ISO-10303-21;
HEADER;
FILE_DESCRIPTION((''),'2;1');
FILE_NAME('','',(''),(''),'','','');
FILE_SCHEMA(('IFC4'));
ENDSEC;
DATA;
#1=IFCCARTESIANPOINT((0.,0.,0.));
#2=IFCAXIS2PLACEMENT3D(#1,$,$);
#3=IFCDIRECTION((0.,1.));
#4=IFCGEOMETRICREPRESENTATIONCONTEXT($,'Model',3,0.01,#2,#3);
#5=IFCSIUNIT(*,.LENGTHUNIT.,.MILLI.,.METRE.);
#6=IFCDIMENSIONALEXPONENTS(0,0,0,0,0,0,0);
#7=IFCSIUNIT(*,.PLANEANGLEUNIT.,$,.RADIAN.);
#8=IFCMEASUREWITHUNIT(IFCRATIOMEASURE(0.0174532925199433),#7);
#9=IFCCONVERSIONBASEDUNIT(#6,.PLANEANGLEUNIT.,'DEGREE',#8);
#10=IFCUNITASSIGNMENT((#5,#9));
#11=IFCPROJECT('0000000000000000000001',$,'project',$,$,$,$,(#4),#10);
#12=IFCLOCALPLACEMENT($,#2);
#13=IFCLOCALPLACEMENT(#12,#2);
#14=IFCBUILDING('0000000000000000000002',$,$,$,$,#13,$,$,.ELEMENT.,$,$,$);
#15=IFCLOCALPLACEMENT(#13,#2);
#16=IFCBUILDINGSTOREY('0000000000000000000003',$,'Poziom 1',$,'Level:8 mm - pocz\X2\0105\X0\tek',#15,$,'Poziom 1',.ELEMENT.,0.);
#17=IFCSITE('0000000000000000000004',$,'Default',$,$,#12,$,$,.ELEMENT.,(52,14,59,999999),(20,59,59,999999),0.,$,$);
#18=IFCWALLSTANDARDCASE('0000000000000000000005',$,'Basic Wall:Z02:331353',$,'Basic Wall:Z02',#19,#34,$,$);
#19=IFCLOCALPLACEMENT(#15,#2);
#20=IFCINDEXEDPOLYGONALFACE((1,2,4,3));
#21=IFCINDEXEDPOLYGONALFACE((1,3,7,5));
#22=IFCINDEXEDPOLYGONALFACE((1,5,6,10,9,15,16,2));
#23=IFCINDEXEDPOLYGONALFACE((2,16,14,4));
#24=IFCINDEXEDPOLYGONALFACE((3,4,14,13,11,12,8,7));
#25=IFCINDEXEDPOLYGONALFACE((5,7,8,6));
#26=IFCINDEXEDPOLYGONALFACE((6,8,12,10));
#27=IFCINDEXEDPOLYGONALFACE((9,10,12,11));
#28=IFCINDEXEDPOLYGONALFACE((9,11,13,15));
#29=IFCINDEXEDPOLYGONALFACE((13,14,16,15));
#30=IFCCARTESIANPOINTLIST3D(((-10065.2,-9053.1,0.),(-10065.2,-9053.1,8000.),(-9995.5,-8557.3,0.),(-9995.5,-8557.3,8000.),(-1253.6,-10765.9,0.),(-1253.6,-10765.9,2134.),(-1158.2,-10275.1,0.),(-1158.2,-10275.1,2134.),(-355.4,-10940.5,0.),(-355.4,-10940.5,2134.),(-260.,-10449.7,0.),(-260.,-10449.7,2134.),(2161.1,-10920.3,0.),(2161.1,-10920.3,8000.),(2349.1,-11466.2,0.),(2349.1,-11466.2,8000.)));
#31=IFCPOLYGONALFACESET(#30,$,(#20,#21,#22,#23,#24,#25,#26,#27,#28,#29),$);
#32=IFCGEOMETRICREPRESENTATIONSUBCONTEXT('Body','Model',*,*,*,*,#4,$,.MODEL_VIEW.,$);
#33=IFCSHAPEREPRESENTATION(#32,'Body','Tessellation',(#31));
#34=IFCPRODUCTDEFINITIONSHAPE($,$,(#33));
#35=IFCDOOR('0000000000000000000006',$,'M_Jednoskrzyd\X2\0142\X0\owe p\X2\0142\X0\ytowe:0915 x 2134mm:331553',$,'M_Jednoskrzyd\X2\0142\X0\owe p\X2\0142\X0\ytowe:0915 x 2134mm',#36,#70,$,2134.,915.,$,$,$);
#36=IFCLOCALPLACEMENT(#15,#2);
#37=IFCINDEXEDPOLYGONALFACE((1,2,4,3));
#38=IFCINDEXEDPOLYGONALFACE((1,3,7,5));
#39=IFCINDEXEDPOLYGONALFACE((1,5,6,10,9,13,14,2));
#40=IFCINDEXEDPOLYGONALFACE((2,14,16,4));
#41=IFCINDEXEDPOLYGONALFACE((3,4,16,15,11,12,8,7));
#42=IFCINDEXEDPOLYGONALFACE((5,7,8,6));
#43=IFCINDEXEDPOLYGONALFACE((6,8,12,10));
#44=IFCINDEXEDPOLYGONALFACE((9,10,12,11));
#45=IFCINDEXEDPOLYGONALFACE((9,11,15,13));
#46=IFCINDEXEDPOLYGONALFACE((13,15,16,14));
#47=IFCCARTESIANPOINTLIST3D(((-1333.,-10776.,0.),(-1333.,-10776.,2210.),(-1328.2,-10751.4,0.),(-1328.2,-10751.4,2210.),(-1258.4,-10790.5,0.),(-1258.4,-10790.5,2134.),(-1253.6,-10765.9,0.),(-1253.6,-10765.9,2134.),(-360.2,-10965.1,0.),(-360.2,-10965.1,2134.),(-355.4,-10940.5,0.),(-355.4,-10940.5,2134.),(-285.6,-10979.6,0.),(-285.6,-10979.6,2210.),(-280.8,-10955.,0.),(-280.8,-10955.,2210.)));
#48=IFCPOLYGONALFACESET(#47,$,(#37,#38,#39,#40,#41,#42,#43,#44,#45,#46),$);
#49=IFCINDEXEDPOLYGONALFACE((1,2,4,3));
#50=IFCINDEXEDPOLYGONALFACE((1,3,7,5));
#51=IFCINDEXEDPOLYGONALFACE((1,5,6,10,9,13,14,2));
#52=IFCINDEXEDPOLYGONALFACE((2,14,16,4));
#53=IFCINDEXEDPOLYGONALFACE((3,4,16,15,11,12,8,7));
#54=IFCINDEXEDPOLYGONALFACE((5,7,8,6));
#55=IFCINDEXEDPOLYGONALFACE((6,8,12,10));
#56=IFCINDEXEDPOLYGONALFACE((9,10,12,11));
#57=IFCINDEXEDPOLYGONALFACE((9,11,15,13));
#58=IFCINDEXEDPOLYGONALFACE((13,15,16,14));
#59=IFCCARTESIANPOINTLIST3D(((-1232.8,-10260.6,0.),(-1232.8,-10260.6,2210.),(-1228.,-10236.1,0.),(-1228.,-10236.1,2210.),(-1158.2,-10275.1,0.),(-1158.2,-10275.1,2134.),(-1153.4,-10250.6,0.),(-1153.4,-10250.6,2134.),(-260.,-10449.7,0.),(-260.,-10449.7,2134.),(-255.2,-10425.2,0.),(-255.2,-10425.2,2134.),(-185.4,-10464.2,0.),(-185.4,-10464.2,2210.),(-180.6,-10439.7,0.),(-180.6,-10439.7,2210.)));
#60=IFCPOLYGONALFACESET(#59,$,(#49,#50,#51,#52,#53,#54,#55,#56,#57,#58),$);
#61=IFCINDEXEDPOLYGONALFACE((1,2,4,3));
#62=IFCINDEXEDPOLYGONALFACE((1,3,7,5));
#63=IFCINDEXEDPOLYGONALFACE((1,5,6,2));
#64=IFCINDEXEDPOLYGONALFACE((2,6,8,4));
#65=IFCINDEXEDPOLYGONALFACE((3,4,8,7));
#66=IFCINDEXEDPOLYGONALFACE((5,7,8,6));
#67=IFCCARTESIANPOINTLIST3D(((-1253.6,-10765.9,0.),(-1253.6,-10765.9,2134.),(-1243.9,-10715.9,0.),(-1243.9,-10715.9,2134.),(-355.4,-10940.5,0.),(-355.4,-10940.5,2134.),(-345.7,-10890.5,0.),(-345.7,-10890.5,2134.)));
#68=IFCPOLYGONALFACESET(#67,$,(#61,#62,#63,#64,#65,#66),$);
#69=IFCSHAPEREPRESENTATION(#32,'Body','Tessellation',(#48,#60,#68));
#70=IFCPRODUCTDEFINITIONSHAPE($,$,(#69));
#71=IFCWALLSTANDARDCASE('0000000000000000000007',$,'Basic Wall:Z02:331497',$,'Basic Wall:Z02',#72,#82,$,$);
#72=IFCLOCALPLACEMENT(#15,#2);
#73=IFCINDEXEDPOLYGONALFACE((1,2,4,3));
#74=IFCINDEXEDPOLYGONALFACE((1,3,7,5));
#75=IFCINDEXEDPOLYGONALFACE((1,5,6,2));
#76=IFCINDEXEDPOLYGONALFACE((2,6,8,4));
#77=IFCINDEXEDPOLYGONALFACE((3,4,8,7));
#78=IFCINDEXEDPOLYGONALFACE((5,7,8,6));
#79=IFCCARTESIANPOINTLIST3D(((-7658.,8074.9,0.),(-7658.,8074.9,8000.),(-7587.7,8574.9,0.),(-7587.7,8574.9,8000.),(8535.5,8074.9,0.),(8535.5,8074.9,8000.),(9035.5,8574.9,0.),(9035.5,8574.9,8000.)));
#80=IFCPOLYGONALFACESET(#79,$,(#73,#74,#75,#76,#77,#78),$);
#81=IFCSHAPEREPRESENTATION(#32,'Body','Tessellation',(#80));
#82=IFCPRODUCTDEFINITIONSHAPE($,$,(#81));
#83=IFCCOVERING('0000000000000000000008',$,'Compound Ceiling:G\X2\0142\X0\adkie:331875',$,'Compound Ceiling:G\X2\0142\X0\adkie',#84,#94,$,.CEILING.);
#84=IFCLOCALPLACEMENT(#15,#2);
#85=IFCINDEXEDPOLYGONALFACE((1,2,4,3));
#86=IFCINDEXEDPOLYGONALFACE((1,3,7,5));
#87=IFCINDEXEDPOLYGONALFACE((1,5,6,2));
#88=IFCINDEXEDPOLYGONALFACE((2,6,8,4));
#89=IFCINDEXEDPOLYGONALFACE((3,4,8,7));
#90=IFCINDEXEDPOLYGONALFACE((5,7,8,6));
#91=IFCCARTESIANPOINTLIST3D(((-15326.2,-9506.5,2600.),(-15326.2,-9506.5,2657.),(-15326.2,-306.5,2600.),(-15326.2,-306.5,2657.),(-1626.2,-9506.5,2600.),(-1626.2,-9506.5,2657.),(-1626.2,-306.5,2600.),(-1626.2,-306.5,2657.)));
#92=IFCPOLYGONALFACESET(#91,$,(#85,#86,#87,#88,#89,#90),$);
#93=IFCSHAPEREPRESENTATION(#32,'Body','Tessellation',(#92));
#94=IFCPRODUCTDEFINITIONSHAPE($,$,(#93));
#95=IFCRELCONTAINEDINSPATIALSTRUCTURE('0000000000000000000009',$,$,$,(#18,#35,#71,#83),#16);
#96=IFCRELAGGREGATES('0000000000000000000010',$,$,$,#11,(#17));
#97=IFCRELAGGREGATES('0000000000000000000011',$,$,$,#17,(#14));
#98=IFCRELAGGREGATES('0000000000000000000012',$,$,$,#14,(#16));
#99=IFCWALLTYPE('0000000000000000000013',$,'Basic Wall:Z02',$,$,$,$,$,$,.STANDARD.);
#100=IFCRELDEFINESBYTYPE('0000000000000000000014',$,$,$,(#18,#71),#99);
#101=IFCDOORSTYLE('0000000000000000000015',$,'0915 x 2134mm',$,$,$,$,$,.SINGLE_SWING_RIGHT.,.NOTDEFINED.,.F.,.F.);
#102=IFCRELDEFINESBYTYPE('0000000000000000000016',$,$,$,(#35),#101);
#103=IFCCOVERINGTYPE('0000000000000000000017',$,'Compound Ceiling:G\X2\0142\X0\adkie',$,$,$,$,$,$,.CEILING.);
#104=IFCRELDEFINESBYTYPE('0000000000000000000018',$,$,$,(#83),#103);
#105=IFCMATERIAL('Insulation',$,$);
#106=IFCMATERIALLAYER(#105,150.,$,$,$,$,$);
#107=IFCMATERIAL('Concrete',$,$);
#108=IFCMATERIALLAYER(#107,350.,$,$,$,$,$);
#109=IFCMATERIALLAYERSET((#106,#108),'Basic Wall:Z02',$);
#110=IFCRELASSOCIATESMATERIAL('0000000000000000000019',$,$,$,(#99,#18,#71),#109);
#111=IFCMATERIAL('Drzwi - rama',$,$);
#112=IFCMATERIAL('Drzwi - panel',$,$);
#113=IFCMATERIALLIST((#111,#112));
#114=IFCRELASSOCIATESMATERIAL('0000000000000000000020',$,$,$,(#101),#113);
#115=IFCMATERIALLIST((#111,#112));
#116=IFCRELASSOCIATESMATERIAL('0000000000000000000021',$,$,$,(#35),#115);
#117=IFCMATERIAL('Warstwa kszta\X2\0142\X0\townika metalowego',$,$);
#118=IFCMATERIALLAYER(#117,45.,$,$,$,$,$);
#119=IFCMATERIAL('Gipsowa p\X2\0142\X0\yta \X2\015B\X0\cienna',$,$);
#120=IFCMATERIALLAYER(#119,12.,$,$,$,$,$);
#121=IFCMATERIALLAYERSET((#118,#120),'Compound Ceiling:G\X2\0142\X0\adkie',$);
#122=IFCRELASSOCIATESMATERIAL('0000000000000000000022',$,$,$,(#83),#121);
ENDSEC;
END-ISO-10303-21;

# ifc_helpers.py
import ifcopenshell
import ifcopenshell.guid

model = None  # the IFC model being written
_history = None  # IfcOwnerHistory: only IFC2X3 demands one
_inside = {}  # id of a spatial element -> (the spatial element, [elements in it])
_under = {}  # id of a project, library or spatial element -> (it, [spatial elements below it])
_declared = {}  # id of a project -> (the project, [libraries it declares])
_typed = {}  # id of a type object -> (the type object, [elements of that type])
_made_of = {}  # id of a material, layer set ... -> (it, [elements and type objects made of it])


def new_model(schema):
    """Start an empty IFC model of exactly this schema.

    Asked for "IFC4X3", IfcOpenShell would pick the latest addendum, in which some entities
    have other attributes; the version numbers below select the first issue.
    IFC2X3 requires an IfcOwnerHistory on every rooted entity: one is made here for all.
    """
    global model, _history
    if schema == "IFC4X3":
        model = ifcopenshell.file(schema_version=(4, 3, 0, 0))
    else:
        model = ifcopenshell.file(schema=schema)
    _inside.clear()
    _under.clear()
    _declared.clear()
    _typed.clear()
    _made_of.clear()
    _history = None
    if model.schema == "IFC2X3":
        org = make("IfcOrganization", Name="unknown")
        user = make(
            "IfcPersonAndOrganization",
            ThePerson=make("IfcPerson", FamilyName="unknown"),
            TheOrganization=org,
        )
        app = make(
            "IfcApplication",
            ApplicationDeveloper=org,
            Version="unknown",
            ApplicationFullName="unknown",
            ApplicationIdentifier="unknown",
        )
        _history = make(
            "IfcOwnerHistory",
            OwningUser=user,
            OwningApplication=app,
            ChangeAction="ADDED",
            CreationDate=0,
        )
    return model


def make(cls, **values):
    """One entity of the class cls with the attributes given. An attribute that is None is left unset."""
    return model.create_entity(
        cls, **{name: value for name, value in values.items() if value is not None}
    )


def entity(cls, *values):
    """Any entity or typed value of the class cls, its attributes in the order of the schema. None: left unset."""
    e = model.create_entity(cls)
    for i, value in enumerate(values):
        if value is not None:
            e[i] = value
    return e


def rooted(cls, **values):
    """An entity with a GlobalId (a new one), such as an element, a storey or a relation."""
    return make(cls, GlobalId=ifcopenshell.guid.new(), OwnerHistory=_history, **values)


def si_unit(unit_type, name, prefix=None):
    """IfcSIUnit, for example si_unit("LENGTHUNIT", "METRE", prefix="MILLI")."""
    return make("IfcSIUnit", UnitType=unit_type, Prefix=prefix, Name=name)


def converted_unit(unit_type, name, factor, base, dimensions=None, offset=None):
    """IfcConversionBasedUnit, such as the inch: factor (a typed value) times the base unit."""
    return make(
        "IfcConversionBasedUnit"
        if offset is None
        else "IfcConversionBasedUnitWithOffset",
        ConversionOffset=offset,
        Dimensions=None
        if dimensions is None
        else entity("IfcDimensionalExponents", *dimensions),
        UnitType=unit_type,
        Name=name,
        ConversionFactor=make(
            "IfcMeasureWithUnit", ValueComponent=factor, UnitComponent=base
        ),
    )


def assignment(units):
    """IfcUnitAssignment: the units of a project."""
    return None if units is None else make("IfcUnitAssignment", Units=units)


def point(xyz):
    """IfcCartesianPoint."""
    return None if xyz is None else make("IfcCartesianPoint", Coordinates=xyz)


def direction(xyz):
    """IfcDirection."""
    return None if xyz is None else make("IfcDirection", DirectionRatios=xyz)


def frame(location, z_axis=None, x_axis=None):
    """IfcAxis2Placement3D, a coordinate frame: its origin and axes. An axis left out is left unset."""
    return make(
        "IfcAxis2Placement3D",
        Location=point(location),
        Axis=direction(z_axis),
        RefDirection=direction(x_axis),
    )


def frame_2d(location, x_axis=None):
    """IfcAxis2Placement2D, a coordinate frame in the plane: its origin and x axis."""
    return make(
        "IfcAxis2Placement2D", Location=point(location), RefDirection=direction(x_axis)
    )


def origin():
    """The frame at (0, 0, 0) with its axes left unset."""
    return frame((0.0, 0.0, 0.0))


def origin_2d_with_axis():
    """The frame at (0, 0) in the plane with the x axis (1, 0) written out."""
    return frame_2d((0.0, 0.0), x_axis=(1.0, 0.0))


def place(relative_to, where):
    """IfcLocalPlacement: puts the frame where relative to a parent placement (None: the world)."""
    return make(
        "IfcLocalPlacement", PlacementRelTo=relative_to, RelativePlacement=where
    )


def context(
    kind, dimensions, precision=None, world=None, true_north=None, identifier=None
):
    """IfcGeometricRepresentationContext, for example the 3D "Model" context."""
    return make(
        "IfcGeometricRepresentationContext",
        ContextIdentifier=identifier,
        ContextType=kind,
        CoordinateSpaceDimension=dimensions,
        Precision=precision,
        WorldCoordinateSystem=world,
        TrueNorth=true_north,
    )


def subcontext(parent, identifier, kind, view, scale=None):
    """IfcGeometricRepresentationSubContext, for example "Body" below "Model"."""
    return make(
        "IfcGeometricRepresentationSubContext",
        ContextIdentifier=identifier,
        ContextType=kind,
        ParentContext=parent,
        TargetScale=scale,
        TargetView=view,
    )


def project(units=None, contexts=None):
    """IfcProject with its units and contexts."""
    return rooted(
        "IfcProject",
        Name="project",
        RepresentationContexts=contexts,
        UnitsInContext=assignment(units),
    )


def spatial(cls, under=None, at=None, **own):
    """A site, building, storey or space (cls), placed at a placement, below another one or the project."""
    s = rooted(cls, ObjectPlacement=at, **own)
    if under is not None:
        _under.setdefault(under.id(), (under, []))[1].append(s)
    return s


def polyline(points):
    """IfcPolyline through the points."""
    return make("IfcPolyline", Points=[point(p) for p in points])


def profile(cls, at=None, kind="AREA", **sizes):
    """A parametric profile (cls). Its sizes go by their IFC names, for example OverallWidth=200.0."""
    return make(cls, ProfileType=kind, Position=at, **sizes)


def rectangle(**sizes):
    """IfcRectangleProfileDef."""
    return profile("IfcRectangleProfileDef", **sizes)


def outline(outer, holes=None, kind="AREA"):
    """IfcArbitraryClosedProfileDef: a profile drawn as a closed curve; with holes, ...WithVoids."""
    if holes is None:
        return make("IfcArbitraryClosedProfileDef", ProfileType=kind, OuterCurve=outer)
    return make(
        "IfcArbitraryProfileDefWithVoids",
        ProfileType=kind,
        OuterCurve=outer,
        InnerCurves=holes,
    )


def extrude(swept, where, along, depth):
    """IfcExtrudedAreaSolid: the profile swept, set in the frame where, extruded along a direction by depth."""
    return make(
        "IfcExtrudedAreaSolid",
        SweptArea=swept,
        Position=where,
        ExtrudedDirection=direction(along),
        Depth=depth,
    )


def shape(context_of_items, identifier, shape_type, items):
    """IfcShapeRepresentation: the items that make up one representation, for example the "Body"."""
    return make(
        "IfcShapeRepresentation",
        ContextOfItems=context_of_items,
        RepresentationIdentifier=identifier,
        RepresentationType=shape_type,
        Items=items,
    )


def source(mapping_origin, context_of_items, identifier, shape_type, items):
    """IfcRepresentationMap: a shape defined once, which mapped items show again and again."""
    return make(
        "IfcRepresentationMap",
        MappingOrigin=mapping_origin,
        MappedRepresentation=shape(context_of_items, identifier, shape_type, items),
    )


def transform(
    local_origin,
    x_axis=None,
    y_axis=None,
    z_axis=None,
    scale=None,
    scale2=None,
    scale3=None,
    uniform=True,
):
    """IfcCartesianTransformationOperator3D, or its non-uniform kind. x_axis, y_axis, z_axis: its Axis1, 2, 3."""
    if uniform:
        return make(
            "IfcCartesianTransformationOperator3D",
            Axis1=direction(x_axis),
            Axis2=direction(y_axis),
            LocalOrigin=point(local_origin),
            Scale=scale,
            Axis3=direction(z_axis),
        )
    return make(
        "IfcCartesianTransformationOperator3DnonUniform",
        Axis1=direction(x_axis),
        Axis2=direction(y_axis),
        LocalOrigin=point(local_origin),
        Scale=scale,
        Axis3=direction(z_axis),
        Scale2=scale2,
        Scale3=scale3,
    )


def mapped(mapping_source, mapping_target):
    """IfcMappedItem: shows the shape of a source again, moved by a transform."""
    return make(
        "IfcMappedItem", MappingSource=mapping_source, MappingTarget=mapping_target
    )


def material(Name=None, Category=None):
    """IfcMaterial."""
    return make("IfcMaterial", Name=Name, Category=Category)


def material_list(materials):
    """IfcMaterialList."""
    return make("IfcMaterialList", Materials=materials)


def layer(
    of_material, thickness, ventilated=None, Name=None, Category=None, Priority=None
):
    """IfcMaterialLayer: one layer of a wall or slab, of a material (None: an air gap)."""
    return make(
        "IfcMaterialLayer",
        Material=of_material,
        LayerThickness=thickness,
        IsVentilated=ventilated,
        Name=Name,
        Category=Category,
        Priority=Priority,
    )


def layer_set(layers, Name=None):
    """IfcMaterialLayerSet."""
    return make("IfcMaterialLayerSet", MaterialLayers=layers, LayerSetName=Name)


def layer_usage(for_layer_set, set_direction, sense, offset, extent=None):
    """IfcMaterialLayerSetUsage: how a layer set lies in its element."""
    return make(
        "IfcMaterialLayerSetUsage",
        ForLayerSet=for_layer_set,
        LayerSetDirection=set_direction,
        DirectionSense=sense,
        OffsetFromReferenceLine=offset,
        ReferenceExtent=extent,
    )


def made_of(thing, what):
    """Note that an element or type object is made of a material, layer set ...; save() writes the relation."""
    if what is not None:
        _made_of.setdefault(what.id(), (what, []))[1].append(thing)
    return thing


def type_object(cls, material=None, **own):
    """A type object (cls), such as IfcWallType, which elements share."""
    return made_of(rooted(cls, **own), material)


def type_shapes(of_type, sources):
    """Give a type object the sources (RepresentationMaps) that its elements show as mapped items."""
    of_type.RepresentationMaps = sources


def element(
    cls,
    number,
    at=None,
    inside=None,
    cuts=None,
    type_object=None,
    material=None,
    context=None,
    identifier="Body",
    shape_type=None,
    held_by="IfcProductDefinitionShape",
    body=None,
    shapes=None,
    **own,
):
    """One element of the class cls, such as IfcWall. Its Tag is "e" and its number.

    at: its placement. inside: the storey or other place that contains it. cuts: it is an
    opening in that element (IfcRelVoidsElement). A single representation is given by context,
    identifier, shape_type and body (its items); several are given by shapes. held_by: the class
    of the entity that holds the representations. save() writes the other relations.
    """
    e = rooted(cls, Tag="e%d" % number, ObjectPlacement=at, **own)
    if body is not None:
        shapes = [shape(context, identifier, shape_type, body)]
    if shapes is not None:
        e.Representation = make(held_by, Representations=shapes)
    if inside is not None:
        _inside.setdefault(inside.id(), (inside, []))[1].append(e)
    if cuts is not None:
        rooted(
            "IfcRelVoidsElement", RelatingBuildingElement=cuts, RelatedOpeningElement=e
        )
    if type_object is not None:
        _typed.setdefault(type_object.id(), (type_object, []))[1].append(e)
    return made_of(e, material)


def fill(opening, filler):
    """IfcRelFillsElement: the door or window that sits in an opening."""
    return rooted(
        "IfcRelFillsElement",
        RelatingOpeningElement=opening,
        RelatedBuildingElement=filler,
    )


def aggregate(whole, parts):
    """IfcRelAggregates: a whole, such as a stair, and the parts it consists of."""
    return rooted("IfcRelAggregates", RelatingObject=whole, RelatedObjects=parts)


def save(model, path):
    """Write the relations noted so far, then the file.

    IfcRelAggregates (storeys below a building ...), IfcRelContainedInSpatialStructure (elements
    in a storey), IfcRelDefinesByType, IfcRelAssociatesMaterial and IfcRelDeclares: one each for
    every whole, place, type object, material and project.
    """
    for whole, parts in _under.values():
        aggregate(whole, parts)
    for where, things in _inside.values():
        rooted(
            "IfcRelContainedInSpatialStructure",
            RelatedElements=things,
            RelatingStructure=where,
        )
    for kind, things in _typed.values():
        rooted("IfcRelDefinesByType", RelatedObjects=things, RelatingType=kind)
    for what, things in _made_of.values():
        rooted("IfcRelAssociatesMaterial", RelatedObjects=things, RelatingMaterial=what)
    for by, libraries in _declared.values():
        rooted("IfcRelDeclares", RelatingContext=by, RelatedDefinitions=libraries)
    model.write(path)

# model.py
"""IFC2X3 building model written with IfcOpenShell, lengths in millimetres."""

from ifc_helpers import new_model, entity, si_unit, converted_unit, direction, frame, frame_2d, origin, origin_2d_with_axis, place, context, subcontext, project, spatial, polyline, rectangle, outline, extrude, source, transform, mapped, material, material_list, layer, layer_set, layer_usage, type_object, type_shapes, element, fill, save


model = new_model("IFC2X3")

# Units and contexts
model_context = context("Model", 3, precision=0.01, world=origin(), true_north=direction((0.0, 1.0)))
body_context = subcontext(model_context, "Body", "Model", "MODEL_VIEW")
ifc_project = project(units=[si_unit("LENGTHUNIT", "METRE", prefix="MILLI"), converted_unit("PLANEANGLEUNIT", "DEGREE", entity("IfcRatioMeasure", 0.0174532925199433), si_unit("PLANEANGLEUNIT", "RADIAN"), dimensions=[0, 0, 0, 0, 0, 0, 0])], contexts=[model_context])

# Site, building, storey
site_placement = place(None, origin())
site = spatial("IfcSite", under=ifc_project, at=site_placement, Name="Default", CompositionType="ELEMENT", RefLatitude=(52, 14, 59, 999999), RefLongitude=(20, 59, 59, 999999), RefElevation=0.0)
building_placement = place(site_placement, origin())
building = spatial("IfcBuilding", under=site, at=building_placement, CompositionType="ELEMENT")
storey_placement = place(building_placement, origin())
storey = spatial("IfcBuildingStorey", under=building, at=storey_placement, Name="Poziom 1", ObjectType="Level:8 mm - początek", LongName="Poziom 1", CompositionType="ELEMENT", Elevation=0.0)

# Wall, opening, door
ifc_material_1 = material(Name="Insulation")
ifc_layer_1 = layer(ifc_material_1, 150.0)
ifc_material_2 = material(Name="Concrete")
ifc_layer_2 = layer(ifc_material_2, 350.0)
ifc_layer_set_1 = layer_set([ifc_layer_1, ifc_layer_2], Name="Basic Wall:Z02")
ifc_layer_usage_1 = layer_usage(ifc_layer_set_1, "AXIS2", "NEGATIVE", 250.0)
wall_type_1 = type_object("IfcWallType", Name="Basic Wall:Z02", PredefinedType="STANDARD", material=ifc_layer_set_1)
wall_1_placement = place(storey_placement, frame((-10043.2, -8802.7, 0.0), z_axis=(0.0, 0.0, 1.0), x_axis=(0.981627, -0.190809, 0.0)))
wall_1 = element("IfcWallStandardCase", 1, at=wall_1_placement, inside=storey, type_object=wall_type_1, material=ifc_layer_usage_1, Name="Basic Wall:Z02:331353", ObjectType="Basic Wall:Z02", context=body_context, shape_type="SweptSolid", body=[
    extrude(outline(polyline([(26.2, -250.0), (12672.8, -250.0), (12384.1, 250.0), (12153.2, 250.0), (0.0, 250.0), (26.2, -250.0)])), origin(), (0.0, 0.0, 1.0), 8000.0),
])
opening_1_placement = place(wall_1_placement, frame((9917.7, 250.0, 0.0)))
opening_1 = element("IfcOpeningElement", 2, at=opening_1_placement, cuts=wall_1, ObjectType="Opening", context=body_context, shape_type="SweptSolid", body=[
    extrude(rectangle(XDim=915.0, YDim=2134.0, at=frame_2d((1067.0, 457.5), x_axis=(0.0, 1.0))), frame((0.0, 0.0, 0.0), z_axis=(0.0, -1.0, 0.0), x_axis=(0.0, 0.0, 1.0)), (0.0, 0.0, 1.0), 500.0),
])
ifc_material_3 = material(Name="Drzwi - rama")
ifc_material_4 = material(Name="Drzwi - panel")
ifc_material_list_1 = material_list([ifc_material_3, ifc_material_4])
ifc_material_list_2 = material_list([ifc_material_3, ifc_material_4])
door_style = type_object("IfcDoorStyle", Name="0915 x 2134mm", ConstructionType="NOTDEFINED", OperationType="SINGLE_SWING_RIGHT", ParameterTakesPrecedence=False, Sizeable=False, material=ifc_material_list_2)
shared_shape_1 = source(origin(), body_context, "Body", "SweptSolid", [
    extrude(outline(polyline([(-533.5, -1124.0), (533.5, -1124.0), (533.5, 1086.0), (457.5, 1086.0), (457.5, -1048.0), (-457.5, -1048.0), (-457.5, 1086.0), (-533.5, 1086.0), (-533.5, -1124.0)])), frame((457.5, 500.0, 1086.0), z_axis=(0.0, 1.0, 0.0), x_axis=(1.0, 0.0, 0.0)), (0.0, 0.0, 1.0), 25.0),
    extrude(outline(polyline([(-1124.0, -533.5), (1086.0, -533.5), (1086.0, -457.5), (-1048.0, -457.5), (-1048.0, 457.5), (1086.0, 457.5), (1086.0, 533.5), (-1124.0, 533.5), (-1124.0, -533.5)])), frame((457.5, -25.0, 1086.0), z_axis=(0.0, 1.0, 0.0), x_axis=(0.0, 0.0, -1.0)), (0.0, 0.0, 1.0), 25.0),
    extrude(rectangle(XDim=51.0, YDim=915.0, at=frame_2d((0.0, 0.0), x_axis=(1.0, 0.0))), frame((457.5, 474.5, 0.0), z_axis=(0.0, 0.0, 1.0), x_axis=(0.0, 1.0, 0.0)), (0.0, 0.0, 1.0), 2134.0),
])
type_shapes(door_style, [shared_shape_1])
door_placement = place(opening_1_placement, frame((0.0, 0.0, 0.0), z_axis=(0.0, 0.0, 1.0), x_axis=(-1.0, 0.0, 0.0)))
door = element("IfcDoor", 3, at=door_placement, inside=storey, type_object=door_style, material=ifc_material_list_1, Name="M_Jednoskrzydłowe płytowe:0915 x 2134mm:331553", ObjectType="M_Jednoskrzydłowe płytowe:0915 x 2134mm", OverallHeight=2134.0, OverallWidth=915.0, context=body_context, shape_type="MappedRepresentation", body=[
    mapped(shared_shape_1, transform((0.0, 0.0, 0.0), scale=1.0)),
])
fill(opening_1, door)

# Wall
ifc_layer_usage_2 = layer_usage(ifc_layer_set_1, "AXIS2", "NEGATIVE", 250.0)
wall_2_placement = place(storey_placement, frame((9035.5, 8324.9, 0.0), z_axis=(0.0, 0.0, 1.0), x_axis=(-1.0, 0.0, 0.0)))
element("IfcWallStandardCase", 4, at=wall_2_placement, inside=storey, type_object=wall_type_1, material=ifc_layer_usage_2, Name="Basic Wall:Z02:331497", ObjectType="Basic Wall:Z02", context=body_context, shape_type="SweptSolid", body=[
    extrude(outline(polyline([(16623.2, -250.0), (16693.5, 250.0), (500.0, 250.0), (0.0, -250.0), (16623.2, -250.0)])), origin(), (0.0, 0.0, 1.0), 8000.0),
])

# Covering
ifc_material_5 = material(Name="Warstwa kształtownika metalowego")
ifc_layer_3 = layer(ifc_material_5, 45.0)
ifc_material_6 = material(Name="Gipsowa płyta ścienna")
ifc_layer_4 = layer(ifc_material_6, 12.0)
ifc_layer_set_2 = layer_set([ifc_layer_3, ifc_layer_4], Name="Compound Ceiling:Gładkie")
ifc_layer_usage_3 = layer_usage(ifc_layer_set_2, "AXIS3", "POSITIVE", 0.0)
covering_type = type_object("IfcCoveringType", Name="Compound Ceiling:Gładkie", PredefinedType="CEILING")
covering_placement = place(storey_placement, origin())
element("IfcCovering", 5, at=covering_placement, inside=storey, type_object=covering_type, material=ifc_layer_usage_3, Name="Compound Ceiling:Gładkie:331875", ObjectType="Compound Ceiling:Gładkie", PredefinedType="CEILING", context=body_context, shape_type="SweptSolid", body=[
    extrude(rectangle(XDim=13700.0, YDim=9200.0, at=origin_2d_with_axis()), frame((-8476.2, -4906.5, 2600.0), z_axis=(0.0, 0.0, 1.0), x_axis=(-1.0, 0.0, 0.0)), (0.0, 0.0, 1.0), 57.0),
])

save(model, "model.ifc")
